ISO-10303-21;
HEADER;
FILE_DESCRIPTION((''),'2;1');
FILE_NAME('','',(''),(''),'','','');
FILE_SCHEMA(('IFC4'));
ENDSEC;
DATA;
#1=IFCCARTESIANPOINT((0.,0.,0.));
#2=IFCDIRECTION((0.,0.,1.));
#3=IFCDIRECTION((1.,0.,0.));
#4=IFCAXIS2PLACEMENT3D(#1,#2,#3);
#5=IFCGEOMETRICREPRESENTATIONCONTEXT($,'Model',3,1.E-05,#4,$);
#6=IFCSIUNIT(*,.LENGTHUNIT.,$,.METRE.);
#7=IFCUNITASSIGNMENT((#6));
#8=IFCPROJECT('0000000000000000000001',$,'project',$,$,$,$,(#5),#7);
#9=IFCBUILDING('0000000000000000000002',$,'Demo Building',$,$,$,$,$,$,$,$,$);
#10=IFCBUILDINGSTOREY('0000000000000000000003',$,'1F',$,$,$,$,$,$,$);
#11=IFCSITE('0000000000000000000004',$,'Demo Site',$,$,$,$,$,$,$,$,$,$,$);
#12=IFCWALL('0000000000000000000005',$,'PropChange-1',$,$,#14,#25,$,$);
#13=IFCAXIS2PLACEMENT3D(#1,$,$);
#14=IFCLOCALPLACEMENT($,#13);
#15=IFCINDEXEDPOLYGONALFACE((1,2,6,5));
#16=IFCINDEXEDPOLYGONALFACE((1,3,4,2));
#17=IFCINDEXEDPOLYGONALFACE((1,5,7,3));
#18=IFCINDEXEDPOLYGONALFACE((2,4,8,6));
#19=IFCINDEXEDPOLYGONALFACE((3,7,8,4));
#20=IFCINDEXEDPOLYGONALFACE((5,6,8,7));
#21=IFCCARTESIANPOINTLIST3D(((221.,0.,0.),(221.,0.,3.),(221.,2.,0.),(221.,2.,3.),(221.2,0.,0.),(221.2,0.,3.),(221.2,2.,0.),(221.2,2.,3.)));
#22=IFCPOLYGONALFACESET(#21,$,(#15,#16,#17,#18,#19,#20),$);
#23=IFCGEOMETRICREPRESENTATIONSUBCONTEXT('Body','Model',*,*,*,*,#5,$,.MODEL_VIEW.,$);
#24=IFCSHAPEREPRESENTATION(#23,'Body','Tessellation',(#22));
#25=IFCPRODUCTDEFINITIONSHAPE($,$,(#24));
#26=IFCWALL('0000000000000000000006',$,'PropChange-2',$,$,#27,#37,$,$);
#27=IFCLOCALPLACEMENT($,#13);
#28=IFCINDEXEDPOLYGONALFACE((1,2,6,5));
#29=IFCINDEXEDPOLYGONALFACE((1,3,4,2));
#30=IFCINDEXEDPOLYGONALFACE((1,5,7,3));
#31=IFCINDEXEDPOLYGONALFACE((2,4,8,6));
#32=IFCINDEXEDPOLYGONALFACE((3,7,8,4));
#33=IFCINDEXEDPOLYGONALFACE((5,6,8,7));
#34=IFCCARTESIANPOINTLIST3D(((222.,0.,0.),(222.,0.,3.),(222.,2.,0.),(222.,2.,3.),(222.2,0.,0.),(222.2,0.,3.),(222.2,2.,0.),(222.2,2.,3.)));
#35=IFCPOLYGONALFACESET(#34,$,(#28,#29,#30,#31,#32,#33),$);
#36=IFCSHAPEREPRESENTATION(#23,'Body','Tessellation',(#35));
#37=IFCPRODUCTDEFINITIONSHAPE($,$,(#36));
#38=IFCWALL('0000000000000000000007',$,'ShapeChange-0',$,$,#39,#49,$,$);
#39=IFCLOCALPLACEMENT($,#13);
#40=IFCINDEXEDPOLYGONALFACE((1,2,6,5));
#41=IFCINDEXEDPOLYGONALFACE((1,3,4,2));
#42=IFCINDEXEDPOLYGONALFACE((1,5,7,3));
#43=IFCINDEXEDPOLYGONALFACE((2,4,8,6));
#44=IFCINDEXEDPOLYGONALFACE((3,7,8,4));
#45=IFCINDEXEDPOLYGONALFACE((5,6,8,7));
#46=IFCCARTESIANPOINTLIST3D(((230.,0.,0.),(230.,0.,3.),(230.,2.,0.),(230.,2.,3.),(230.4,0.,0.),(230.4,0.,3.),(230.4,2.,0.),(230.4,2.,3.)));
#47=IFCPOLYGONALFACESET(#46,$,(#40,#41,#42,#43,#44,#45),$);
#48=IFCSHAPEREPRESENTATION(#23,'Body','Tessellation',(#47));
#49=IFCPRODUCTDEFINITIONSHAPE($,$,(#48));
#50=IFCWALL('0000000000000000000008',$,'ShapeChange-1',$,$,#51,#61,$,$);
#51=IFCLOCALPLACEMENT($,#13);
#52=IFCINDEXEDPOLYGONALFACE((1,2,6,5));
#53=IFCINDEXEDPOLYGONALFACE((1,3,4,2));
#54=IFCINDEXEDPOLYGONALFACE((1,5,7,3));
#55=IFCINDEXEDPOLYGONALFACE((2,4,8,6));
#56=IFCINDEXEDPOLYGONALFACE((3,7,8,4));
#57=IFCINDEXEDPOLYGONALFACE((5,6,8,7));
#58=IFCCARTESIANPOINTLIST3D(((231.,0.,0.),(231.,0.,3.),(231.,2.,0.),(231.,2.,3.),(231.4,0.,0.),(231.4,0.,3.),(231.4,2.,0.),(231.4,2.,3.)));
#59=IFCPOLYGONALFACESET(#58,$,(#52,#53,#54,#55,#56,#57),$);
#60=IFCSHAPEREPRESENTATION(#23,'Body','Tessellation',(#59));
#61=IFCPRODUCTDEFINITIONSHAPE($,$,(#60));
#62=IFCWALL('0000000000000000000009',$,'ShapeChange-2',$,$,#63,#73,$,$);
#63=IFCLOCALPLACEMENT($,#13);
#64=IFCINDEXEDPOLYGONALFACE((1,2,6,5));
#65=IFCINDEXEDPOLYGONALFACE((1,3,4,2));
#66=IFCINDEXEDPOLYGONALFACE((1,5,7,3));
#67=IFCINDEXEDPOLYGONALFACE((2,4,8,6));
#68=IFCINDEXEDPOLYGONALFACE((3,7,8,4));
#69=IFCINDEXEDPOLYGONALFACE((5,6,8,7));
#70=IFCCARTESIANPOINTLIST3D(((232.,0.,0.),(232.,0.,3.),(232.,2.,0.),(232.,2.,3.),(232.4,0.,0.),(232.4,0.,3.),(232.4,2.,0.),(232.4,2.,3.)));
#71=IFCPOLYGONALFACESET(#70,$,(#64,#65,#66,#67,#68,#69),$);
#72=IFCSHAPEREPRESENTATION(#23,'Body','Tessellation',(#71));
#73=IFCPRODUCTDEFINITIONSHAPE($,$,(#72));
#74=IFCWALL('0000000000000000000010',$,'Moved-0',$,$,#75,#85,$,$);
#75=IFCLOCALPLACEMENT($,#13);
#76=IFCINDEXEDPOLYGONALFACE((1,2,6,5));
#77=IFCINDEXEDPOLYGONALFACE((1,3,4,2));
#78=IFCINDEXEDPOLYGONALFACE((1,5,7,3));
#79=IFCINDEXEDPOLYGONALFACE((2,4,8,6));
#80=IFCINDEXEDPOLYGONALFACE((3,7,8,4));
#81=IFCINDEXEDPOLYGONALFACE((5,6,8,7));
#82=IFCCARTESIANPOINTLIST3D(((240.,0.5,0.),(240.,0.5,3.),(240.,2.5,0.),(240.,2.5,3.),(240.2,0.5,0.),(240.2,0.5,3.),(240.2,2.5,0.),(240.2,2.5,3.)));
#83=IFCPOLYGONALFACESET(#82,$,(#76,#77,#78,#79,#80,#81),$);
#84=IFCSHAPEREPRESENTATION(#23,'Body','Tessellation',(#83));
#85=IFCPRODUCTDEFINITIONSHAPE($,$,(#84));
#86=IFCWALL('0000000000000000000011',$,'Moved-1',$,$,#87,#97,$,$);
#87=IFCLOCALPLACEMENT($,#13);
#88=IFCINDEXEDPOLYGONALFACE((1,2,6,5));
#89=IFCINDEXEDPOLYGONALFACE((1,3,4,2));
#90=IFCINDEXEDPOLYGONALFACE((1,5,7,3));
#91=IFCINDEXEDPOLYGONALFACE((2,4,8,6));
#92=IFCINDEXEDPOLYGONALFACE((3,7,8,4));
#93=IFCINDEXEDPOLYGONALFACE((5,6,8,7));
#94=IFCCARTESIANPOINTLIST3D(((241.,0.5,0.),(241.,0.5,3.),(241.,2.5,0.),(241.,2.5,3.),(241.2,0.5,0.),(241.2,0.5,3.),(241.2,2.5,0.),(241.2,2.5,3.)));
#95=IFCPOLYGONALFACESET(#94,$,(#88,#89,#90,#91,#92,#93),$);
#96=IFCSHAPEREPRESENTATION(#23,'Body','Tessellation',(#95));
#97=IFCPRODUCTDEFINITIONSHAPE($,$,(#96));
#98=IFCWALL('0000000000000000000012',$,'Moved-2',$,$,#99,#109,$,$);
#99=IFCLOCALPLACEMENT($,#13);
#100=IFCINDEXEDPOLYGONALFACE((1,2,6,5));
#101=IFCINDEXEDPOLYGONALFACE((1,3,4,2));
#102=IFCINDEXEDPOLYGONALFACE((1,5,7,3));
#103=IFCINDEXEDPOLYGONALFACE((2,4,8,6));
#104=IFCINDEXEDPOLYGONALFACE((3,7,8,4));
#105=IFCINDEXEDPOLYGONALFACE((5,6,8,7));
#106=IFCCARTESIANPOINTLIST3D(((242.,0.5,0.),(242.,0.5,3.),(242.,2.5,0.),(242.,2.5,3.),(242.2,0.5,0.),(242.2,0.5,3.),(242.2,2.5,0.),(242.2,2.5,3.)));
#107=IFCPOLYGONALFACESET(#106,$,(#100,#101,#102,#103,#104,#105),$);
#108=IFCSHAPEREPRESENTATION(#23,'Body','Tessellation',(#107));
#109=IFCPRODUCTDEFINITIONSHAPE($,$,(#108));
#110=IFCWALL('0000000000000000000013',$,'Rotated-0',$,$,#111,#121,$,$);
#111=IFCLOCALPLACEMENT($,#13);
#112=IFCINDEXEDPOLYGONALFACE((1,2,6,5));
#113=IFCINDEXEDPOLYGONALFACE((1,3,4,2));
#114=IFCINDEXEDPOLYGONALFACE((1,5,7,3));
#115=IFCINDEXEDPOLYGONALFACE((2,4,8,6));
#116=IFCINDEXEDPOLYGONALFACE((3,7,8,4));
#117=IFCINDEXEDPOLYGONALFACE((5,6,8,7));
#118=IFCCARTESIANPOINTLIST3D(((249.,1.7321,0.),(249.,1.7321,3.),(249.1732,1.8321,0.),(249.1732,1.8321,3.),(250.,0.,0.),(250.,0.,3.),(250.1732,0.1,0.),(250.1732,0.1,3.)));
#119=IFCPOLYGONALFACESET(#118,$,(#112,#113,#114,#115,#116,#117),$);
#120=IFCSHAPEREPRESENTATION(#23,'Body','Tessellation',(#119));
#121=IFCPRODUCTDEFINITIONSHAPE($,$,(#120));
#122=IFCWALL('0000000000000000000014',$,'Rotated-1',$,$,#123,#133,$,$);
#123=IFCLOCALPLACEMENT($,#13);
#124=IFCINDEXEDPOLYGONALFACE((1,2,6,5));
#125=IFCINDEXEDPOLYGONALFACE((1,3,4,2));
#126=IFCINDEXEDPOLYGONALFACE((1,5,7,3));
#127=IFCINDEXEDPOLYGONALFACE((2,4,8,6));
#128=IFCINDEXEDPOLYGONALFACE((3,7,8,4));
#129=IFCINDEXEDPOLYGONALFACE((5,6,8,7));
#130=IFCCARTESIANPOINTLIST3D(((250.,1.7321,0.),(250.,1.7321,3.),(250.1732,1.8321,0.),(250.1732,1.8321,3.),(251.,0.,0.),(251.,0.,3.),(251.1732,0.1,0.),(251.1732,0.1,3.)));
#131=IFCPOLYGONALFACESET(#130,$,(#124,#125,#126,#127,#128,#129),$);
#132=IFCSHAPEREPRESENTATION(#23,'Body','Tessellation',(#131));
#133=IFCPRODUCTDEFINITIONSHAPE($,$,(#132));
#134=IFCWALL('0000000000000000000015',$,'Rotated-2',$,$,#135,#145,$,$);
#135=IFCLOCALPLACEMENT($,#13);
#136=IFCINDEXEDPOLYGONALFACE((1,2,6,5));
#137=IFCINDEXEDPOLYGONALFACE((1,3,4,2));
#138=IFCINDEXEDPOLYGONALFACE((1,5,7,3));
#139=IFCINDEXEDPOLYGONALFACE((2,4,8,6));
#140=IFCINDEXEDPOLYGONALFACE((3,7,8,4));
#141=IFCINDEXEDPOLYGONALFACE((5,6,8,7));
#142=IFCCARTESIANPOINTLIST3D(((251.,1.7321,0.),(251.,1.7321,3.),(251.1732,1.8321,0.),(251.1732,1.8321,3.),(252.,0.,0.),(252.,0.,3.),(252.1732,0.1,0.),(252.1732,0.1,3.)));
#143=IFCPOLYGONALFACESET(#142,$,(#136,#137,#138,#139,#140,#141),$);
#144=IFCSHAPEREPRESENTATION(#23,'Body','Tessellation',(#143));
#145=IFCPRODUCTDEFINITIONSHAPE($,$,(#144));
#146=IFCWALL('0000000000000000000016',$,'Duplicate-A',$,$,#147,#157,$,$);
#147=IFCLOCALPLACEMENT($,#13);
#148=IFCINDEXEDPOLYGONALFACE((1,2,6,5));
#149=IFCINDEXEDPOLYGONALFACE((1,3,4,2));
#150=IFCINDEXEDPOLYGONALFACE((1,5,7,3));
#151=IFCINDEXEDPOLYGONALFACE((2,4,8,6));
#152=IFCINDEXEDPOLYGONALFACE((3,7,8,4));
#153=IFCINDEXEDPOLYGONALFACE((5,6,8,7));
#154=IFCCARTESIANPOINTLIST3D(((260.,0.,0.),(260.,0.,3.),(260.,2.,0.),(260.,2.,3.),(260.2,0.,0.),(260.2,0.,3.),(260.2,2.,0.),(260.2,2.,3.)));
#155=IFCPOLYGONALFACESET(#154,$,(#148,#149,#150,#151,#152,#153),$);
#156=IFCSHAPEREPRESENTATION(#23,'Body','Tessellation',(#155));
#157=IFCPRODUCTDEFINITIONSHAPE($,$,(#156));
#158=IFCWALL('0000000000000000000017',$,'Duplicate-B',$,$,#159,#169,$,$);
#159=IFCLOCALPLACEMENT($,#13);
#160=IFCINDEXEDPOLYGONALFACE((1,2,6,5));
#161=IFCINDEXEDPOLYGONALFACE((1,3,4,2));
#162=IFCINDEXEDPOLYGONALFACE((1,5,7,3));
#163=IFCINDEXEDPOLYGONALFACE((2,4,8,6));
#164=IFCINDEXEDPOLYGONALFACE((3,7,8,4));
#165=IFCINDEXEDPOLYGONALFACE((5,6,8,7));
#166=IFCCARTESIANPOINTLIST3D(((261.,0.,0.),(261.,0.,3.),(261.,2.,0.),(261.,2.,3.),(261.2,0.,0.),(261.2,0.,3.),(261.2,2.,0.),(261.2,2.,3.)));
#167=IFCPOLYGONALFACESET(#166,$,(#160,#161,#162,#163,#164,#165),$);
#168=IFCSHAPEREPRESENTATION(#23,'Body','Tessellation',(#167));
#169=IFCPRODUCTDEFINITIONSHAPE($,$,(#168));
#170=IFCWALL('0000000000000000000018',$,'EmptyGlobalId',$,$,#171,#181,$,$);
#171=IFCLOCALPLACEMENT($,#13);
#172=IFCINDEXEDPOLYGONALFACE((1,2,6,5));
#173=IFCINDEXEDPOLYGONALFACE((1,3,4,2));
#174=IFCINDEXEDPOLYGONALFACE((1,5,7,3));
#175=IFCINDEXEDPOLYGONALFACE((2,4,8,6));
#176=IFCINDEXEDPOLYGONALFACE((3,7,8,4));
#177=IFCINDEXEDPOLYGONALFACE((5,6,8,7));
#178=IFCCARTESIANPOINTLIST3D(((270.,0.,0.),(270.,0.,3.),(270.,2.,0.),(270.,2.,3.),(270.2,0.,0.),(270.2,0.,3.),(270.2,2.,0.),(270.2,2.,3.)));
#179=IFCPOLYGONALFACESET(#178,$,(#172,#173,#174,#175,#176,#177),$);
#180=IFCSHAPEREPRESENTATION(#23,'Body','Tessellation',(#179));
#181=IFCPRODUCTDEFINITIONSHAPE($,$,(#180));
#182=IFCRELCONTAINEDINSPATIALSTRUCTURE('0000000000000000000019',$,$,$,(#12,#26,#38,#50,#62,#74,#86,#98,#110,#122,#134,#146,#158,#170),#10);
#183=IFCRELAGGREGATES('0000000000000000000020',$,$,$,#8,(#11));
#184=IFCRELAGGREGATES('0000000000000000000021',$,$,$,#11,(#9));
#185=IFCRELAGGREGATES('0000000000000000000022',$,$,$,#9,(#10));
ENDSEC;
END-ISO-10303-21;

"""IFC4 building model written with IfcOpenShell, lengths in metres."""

from ifc_helpers import new_model, entity, si_unit, frame, origin_with_axes, place, context, subcontext, project, spatial, element, save


model = new_model("IFC4")

# Units and contexts
model_context = context("Model", 3, precision=1e-05, world=origin_with_axes())
body_context = subcontext(model_context, "Body", "Model", "MODEL_VIEW")
ifc_project = project(units=[si_unit("LENGTHUNIT", "METRE")], contexts=[model_context])

# Site, building, storey
site = spatial("IfcSite", under=ifc_project, Name="Demo Site")
building = spatial("IfcBuilding", under=site, Name="Demo Building")
storey = spatial("IfcBuildingStorey", under=building, Name="1F")

# Walls
for number, where, z_axis, x_axis, name in (
    (1, (221.0, 0.0, 0.0), (0.0, 0.0, 1.0), (1.0, 0.0, 0.0), "PropChange-1"),
    (2, (222.0, 0.0, 0.0), (0.0, 0.0, 1.0), (1.0, 0.0, 0.0), "PropChange-2"),
):
    element("IfcWall", number, at=place(None, frame(where, z_axis=z_axis, x_axis=x_axis)), inside=storey, Name=name, context=body_context, shape_type="CSG", body=[
        entity("IfcBlock", entity("IfcAxis2Placement3D", entity("IfcCartesianPoint", [0.0, 0.0, 0.0]), entity("IfcDirection", [0.0, 0.0, 1.0]), entity("IfcDirection", [1.0, 0.0, 0.0])), 0.2, 2.0, 3.0),
    ])
for number, where, z_axis, x_axis, name in (
    (3, (230.0, 0.0, 0.0), (0.0, 0.0, 1.0), (1.0, 0.0, 0.0), "ShapeChange-0"),
    (4, (231.0, 0.0, 0.0), (0.0, 0.0, 1.0), (1.0, 0.0, 0.0), "ShapeChange-1"),
    (5, (232.0, 0.0, 0.0), (0.0, 0.0, 1.0), (1.0, 0.0, 0.0), "ShapeChange-2"),
):
    element("IfcWall", number, at=place(None, frame(where, z_axis=z_axis, x_axis=x_axis)), inside=storey, Name=name, context=body_context, shape_type="CSG", body=[
        entity("IfcBlock", entity("IfcAxis2Placement3D", entity("IfcCartesianPoint", [0.0, 0.0, 0.0]), entity("IfcDirection", [0.0, 0.0, 1.0]), entity("IfcDirection", [1.0, 0.0, 0.0])), 0.4, 2.0, 3.0),
    ])
for number, where, z_axis, x_axis, name in (
    (6, (240.0, 0.5, 0.0), (0.0, 0.0, 1.0), (1.0, 0.0, 0.0), "Moved-0"),
    (7, (241.0, 0.5, 0.0), (0.0, 0.0, 1.0), (1.0, 0.0, 0.0), "Moved-1"),
    (8, (242.0, 0.5, 0.0), (0.0, 0.0, 1.0), (1.0, 0.0, 0.0), "Moved-2"),
    (9, (250.0, 0.0, 0.0), (0.0, 0.0, 1.0), (0.866025, 0.5, 0.0), "Rotated-0"),
    (10, (251.0, 0.0, 0.0), (0.0, 0.0, 1.0), (0.866025, 0.5, 0.0), "Rotated-1"),
    (11, (252.0, 0.0, 0.0), (0.0, 0.0, 1.0), (0.866025, 0.5, 0.0), "Rotated-2"),
    (12, (260.0, 0.0, 0.0), (0.0, 0.0, 1.0), (1.0, 0.0, 0.0), "Duplicate-A"),
    (13, (261.0, 0.0, 0.0), (0.0, 0.0, 1.0), (1.0, 0.0, 0.0), "Duplicate-B"),
    (14, (270.0, 0.0, 0.0), (0.0, 0.0, 1.0), (1.0, 0.0, 0.0), "EmptyGlobalId"),
):
    element("IfcWall", number, at=place(None, frame(where, z_axis=z_axis, x_axis=x_axis)), inside=storey, Name=name, context=body_context, shape_type="CSG", body=[
        entity("IfcBlock", entity("IfcAxis2Placement3D", entity("IfcCartesianPoint", [0.0, 0.0, 0.0]), entity("IfcDirection", [0.0, 0.0, 1.0]), entity("IfcDirection", [1.0, 0.0, 0.0])), 0.2, 2.0, 3.0),
    ])

save(model, "model.ifc")
